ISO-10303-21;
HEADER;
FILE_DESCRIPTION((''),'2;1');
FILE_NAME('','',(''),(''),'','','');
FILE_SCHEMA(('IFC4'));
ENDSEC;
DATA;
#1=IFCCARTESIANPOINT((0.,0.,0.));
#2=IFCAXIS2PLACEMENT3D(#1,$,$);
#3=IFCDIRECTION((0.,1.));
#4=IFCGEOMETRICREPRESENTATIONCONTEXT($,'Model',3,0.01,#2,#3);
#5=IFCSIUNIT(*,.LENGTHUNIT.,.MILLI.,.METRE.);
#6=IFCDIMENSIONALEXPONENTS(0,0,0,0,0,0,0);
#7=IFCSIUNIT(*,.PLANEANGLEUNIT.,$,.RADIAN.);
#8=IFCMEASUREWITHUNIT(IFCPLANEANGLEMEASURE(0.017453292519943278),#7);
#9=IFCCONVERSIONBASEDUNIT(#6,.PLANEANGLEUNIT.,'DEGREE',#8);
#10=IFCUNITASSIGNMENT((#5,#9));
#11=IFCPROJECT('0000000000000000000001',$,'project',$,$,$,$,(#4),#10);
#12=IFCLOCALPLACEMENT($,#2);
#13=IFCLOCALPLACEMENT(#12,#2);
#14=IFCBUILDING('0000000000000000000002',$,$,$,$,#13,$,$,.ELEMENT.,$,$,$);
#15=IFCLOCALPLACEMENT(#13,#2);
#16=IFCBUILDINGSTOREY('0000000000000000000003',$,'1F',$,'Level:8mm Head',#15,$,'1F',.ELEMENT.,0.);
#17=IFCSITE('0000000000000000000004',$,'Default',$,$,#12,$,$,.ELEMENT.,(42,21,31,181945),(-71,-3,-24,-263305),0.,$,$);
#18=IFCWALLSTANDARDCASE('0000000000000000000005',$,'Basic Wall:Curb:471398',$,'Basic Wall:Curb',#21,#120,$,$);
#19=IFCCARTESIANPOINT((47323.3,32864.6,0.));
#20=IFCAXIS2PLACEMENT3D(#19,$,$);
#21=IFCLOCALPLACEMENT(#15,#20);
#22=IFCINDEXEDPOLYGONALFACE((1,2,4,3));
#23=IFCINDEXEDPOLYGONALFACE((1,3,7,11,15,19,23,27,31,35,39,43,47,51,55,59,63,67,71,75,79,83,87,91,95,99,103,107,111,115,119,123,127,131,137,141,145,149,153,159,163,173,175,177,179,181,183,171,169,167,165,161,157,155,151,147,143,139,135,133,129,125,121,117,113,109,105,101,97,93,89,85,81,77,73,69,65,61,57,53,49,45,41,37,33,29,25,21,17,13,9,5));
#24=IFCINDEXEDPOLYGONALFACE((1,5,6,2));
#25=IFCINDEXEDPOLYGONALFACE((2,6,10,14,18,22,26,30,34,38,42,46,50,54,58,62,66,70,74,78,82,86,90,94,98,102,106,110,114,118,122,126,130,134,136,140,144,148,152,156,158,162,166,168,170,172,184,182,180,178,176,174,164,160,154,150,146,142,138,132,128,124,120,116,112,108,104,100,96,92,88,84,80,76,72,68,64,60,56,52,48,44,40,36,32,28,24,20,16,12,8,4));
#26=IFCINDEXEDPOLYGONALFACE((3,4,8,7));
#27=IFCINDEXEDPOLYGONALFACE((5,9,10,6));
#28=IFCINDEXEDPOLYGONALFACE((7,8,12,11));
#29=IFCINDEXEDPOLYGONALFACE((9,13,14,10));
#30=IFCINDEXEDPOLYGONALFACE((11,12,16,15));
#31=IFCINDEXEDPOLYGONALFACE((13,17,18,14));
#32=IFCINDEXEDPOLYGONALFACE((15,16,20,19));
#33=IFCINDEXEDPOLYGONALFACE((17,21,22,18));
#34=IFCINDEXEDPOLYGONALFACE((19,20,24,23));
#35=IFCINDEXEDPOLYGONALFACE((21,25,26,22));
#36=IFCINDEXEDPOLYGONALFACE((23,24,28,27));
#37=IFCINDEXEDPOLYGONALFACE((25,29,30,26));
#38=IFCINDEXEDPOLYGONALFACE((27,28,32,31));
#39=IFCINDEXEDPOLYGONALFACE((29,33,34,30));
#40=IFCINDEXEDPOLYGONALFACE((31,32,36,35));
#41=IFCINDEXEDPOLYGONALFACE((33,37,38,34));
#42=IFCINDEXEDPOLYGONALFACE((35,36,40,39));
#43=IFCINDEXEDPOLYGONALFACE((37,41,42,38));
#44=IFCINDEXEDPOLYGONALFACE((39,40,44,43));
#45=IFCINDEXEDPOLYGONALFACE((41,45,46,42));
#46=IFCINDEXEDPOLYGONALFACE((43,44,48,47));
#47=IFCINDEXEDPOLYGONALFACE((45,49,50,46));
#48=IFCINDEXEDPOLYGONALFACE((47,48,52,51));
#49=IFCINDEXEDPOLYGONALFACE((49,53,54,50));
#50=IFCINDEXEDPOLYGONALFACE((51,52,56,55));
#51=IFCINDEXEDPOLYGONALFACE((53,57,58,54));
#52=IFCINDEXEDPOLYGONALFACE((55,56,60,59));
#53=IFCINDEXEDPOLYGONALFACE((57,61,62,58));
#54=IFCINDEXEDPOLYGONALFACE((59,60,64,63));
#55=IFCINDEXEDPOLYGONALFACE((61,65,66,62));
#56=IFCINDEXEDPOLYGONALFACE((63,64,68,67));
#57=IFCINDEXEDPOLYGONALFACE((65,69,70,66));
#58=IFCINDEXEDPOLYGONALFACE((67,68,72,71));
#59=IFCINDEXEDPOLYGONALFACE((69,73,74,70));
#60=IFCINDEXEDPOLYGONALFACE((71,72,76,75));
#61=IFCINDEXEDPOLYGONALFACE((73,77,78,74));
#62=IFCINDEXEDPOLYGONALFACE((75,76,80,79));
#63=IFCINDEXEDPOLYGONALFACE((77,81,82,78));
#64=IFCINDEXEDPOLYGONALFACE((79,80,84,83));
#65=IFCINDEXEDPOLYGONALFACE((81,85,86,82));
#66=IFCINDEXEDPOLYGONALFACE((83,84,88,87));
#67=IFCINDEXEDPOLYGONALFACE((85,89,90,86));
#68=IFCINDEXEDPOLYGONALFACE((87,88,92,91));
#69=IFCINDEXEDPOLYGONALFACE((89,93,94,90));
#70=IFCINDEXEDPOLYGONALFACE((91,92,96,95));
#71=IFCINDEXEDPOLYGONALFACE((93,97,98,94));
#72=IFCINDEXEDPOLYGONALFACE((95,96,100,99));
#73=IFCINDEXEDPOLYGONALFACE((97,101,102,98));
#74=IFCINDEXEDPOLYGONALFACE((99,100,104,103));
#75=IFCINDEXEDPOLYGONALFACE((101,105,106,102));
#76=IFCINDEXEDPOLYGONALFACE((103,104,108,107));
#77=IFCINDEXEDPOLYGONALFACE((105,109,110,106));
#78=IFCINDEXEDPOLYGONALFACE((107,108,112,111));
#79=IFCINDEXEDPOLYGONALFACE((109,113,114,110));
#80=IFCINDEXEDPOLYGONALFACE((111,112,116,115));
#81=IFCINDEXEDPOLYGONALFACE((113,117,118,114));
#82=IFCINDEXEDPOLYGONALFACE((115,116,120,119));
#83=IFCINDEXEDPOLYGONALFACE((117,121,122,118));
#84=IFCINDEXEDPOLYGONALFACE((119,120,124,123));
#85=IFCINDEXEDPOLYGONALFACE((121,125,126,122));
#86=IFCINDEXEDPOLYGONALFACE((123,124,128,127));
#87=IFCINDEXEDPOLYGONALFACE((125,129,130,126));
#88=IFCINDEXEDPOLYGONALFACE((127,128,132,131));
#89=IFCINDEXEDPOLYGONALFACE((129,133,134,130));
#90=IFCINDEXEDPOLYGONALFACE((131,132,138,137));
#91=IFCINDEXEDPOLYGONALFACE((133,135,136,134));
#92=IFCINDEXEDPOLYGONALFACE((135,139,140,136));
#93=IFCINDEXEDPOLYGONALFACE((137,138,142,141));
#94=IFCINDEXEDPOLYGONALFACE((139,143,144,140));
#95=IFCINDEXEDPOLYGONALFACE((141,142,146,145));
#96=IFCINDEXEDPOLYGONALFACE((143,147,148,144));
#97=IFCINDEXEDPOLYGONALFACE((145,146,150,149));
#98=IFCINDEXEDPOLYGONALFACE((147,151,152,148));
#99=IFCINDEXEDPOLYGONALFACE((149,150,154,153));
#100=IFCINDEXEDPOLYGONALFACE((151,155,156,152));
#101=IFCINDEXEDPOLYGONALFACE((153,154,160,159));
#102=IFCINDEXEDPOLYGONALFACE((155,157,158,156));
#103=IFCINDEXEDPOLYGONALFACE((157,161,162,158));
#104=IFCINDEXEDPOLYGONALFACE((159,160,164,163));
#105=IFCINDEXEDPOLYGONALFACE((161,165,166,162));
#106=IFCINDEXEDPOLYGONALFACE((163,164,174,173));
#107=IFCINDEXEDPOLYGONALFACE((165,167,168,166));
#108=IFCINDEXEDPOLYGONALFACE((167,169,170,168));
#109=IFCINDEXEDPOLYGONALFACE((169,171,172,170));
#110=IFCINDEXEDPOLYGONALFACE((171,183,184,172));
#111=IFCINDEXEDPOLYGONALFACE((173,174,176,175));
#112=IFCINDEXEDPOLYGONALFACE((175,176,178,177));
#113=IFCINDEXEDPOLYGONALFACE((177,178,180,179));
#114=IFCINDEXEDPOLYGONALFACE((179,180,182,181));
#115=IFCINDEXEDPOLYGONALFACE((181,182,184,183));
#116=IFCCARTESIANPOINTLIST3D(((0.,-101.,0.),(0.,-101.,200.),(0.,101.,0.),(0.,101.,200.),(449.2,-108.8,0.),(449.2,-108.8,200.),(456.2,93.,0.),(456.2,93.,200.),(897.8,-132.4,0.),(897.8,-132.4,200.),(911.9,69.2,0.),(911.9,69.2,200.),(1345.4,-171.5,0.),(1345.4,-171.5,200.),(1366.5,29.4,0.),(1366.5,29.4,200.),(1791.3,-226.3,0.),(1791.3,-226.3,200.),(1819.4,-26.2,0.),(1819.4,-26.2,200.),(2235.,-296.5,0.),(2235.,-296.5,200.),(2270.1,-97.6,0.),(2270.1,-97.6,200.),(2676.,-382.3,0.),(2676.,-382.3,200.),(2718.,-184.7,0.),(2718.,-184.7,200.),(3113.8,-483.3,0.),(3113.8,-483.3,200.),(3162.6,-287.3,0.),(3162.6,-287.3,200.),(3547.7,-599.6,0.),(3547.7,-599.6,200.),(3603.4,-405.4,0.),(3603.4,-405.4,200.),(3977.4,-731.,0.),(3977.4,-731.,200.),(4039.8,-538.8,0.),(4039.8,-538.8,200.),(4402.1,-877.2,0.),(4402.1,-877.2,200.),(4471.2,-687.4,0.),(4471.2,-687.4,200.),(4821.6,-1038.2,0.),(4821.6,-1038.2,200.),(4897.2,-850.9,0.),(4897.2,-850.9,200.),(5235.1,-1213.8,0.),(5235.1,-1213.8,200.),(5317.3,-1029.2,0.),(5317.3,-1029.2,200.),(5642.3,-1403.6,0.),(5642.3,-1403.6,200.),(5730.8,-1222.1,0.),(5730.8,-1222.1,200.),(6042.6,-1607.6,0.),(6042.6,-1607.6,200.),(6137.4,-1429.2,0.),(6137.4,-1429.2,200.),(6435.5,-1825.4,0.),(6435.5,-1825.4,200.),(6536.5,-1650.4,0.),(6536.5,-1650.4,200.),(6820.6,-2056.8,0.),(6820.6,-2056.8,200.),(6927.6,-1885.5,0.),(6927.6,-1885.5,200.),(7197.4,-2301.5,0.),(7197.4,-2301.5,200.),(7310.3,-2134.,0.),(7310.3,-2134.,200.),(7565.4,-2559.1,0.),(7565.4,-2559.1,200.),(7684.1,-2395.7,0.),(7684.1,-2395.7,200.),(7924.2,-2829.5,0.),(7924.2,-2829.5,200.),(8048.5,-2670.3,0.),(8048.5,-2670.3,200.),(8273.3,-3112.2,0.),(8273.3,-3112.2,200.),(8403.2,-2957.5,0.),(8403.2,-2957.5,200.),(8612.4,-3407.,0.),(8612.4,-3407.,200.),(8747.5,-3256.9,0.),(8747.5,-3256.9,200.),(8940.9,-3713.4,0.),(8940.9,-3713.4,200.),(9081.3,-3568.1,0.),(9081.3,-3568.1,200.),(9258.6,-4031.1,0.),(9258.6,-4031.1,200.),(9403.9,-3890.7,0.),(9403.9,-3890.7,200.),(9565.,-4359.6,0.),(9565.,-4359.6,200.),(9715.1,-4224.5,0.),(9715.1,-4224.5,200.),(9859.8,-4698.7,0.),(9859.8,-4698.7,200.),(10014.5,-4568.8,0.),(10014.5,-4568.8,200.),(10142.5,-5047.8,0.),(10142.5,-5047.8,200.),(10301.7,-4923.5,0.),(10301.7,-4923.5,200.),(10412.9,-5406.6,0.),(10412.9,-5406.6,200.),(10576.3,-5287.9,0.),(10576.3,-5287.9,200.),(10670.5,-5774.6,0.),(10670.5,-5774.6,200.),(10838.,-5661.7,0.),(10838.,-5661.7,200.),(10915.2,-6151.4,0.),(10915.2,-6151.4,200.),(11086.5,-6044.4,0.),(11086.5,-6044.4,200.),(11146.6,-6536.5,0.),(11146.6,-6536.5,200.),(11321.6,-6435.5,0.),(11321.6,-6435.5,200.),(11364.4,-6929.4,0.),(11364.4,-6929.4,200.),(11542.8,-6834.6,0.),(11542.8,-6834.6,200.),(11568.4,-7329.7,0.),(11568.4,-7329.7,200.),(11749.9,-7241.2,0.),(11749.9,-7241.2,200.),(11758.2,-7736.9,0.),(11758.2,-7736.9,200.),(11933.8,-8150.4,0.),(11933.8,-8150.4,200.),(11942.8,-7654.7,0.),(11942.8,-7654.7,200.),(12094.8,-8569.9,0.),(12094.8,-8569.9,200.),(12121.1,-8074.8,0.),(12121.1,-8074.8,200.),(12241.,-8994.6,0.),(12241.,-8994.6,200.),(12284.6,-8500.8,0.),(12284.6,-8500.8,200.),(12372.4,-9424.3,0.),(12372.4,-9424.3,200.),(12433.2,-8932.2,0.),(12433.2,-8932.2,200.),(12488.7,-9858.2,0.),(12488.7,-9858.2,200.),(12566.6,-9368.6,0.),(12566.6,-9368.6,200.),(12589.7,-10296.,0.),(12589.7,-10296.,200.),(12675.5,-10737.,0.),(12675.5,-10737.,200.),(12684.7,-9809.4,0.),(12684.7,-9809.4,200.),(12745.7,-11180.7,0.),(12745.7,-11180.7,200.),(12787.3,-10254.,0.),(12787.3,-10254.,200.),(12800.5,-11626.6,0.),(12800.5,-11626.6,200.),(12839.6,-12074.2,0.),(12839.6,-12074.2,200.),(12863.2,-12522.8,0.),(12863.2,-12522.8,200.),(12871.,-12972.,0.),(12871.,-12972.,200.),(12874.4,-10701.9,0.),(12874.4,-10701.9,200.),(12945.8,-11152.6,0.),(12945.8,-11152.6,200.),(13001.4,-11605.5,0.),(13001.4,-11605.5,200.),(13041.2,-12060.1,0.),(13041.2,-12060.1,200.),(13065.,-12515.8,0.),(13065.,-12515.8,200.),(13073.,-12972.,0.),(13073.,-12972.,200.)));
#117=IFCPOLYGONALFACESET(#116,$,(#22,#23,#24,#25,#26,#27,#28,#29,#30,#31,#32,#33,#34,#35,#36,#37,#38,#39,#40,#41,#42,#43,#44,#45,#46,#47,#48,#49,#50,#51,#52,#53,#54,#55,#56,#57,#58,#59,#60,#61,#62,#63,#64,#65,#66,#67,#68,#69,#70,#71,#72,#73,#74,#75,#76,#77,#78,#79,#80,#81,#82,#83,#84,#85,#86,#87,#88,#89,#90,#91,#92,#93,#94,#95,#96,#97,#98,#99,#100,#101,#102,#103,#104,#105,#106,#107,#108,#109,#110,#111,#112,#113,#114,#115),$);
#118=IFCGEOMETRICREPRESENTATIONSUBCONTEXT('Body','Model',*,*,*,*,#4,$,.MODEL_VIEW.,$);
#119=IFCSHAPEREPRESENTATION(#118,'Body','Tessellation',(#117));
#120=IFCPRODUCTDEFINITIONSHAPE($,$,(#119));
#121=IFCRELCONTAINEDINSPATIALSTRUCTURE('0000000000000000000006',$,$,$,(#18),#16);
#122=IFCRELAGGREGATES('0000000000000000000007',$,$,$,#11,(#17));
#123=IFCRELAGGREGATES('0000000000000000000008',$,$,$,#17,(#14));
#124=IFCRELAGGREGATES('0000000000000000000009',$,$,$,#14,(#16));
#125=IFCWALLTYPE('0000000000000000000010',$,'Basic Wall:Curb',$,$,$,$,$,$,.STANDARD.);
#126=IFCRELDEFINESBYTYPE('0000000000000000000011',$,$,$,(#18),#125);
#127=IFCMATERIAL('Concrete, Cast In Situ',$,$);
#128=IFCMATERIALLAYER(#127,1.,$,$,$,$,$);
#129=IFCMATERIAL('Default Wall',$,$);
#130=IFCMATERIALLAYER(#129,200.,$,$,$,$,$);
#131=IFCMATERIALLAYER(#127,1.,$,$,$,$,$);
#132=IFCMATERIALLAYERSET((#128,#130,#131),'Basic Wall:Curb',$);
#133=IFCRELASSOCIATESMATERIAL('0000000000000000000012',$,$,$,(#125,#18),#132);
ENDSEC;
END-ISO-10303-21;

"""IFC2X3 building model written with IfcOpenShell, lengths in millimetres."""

from ifc_helpers import new_model, entity, si_unit, converted_unit, direction, frame, frame_2d, origin, place, context, subcontext, project, spatial, polyline, circle_curve, parameter, trimmed, segment, composite_curve, outline, extrude, material, layer, layer_set, layer_usage, type_object, element, save


model = new_model("IFC2X3")

# Units and contexts
model_context = context("Model", 3, precision=0.01, world=origin(), true_north=direction((0.0, 1.0)))
body_context = subcontext(model_context, "Body", "Model", "MODEL_VIEW")
ifc_project = project(units=[si_unit("LENGTHUNIT", "METRE", prefix="MILLI"), converted_unit("PLANEANGLEUNIT", "DEGREE", entity("IfcPlaneAngleMeasure", 0.017453292519943278), si_unit("PLANEANGLEUNIT", "RADIAN"), dimensions=[0, 0, 0, 0, 0, 0, 0])], contexts=[model_context])

# Site, building, storey
site_placement = place(None, origin())
site = spatial("IfcSite", under=ifc_project, at=site_placement, Name="Default", CompositionType="ELEMENT", RefLatitude=(42, 21, 31, 181945), RefLongitude=(-71, -3, -24, -263305), RefElevation=0.0)
building_placement = place(site_placement, origin())
building = spatial("IfcBuilding", under=site, at=building_placement, CompositionType="ELEMENT")
storey_placement = place(building_placement, origin())
storey = spatial("IfcBuildingStorey", under=building, at=storey_placement, Name="1F", ObjectType="Level:8mm Head", LongName="1F", CompositionType="ELEMENT", Elevation=0.0)

# Shared definitions
ifc_material_1 = material(Name="Default Wall")

# Wall
ifc_material_2 = material(Name="Concrete, Cast In Situ")
ifc_layer_1 = layer(ifc_material_2, 1.0)
ifc_layer_2 = layer(ifc_material_1, 200.0)
ifc_layer_3 = layer(ifc_material_2, 1.0)
ifc_layer_set_1 = layer_set([ifc_layer_1, ifc_layer_2, ifc_layer_3], Name="Basic Wall:Curb")
wall_type_1 = type_object("IfcWallType", Name="Basic Wall:Curb", PredefinedType="STANDARD", material=ifc_layer_set_1)
ifc_layer_usage_1 = layer_usage(ifc_layer_set_1, "AXIS2", "POSITIVE", -101.0)
wall_1_placement = place(storey_placement, frame((47323.3, 32864.6, 0.0)))
element("IfcWallStandardCase", 1, at=wall_1_placement, inside=storey, type_object=wall_type_1, material=ifc_layer_usage_1, Name="Basic Wall:Curb:471398", ObjectType="Basic Wall:Curb", context=body_context, shape_type="SweptSolid", body=[
    extrude(outline(composite_curve([segment(trimmed(circle_curve(frame_2d((0.0, -12972.0), x_axis=(1.0, 0.0)), 13073.0), [parameter(0.0)], [parameter(90.0)], True, "PARAMETER"), True, "CONTINUOUS"), segment(polyline([(0.0, 101.0), (0.0, -101.0)]), True, "CONTINUOUS"), segment(trimmed(circle_curve(frame_2d((0.0, -12972.0), x_axis=(1.0, 0.0)), 12871.0), [parameter(0.0)], [parameter(90.0)], True, "PARAMETER"), False, "CONTINUOUS"), segment(polyline([(12871.0, -12972.0), (13073.0, -12972.0)]), True, "CONTINUOUS")], self_intersect=False)), origin(), (0.0, 0.0, 1.0), 200.0),
])

save(model, "model.ifc")
